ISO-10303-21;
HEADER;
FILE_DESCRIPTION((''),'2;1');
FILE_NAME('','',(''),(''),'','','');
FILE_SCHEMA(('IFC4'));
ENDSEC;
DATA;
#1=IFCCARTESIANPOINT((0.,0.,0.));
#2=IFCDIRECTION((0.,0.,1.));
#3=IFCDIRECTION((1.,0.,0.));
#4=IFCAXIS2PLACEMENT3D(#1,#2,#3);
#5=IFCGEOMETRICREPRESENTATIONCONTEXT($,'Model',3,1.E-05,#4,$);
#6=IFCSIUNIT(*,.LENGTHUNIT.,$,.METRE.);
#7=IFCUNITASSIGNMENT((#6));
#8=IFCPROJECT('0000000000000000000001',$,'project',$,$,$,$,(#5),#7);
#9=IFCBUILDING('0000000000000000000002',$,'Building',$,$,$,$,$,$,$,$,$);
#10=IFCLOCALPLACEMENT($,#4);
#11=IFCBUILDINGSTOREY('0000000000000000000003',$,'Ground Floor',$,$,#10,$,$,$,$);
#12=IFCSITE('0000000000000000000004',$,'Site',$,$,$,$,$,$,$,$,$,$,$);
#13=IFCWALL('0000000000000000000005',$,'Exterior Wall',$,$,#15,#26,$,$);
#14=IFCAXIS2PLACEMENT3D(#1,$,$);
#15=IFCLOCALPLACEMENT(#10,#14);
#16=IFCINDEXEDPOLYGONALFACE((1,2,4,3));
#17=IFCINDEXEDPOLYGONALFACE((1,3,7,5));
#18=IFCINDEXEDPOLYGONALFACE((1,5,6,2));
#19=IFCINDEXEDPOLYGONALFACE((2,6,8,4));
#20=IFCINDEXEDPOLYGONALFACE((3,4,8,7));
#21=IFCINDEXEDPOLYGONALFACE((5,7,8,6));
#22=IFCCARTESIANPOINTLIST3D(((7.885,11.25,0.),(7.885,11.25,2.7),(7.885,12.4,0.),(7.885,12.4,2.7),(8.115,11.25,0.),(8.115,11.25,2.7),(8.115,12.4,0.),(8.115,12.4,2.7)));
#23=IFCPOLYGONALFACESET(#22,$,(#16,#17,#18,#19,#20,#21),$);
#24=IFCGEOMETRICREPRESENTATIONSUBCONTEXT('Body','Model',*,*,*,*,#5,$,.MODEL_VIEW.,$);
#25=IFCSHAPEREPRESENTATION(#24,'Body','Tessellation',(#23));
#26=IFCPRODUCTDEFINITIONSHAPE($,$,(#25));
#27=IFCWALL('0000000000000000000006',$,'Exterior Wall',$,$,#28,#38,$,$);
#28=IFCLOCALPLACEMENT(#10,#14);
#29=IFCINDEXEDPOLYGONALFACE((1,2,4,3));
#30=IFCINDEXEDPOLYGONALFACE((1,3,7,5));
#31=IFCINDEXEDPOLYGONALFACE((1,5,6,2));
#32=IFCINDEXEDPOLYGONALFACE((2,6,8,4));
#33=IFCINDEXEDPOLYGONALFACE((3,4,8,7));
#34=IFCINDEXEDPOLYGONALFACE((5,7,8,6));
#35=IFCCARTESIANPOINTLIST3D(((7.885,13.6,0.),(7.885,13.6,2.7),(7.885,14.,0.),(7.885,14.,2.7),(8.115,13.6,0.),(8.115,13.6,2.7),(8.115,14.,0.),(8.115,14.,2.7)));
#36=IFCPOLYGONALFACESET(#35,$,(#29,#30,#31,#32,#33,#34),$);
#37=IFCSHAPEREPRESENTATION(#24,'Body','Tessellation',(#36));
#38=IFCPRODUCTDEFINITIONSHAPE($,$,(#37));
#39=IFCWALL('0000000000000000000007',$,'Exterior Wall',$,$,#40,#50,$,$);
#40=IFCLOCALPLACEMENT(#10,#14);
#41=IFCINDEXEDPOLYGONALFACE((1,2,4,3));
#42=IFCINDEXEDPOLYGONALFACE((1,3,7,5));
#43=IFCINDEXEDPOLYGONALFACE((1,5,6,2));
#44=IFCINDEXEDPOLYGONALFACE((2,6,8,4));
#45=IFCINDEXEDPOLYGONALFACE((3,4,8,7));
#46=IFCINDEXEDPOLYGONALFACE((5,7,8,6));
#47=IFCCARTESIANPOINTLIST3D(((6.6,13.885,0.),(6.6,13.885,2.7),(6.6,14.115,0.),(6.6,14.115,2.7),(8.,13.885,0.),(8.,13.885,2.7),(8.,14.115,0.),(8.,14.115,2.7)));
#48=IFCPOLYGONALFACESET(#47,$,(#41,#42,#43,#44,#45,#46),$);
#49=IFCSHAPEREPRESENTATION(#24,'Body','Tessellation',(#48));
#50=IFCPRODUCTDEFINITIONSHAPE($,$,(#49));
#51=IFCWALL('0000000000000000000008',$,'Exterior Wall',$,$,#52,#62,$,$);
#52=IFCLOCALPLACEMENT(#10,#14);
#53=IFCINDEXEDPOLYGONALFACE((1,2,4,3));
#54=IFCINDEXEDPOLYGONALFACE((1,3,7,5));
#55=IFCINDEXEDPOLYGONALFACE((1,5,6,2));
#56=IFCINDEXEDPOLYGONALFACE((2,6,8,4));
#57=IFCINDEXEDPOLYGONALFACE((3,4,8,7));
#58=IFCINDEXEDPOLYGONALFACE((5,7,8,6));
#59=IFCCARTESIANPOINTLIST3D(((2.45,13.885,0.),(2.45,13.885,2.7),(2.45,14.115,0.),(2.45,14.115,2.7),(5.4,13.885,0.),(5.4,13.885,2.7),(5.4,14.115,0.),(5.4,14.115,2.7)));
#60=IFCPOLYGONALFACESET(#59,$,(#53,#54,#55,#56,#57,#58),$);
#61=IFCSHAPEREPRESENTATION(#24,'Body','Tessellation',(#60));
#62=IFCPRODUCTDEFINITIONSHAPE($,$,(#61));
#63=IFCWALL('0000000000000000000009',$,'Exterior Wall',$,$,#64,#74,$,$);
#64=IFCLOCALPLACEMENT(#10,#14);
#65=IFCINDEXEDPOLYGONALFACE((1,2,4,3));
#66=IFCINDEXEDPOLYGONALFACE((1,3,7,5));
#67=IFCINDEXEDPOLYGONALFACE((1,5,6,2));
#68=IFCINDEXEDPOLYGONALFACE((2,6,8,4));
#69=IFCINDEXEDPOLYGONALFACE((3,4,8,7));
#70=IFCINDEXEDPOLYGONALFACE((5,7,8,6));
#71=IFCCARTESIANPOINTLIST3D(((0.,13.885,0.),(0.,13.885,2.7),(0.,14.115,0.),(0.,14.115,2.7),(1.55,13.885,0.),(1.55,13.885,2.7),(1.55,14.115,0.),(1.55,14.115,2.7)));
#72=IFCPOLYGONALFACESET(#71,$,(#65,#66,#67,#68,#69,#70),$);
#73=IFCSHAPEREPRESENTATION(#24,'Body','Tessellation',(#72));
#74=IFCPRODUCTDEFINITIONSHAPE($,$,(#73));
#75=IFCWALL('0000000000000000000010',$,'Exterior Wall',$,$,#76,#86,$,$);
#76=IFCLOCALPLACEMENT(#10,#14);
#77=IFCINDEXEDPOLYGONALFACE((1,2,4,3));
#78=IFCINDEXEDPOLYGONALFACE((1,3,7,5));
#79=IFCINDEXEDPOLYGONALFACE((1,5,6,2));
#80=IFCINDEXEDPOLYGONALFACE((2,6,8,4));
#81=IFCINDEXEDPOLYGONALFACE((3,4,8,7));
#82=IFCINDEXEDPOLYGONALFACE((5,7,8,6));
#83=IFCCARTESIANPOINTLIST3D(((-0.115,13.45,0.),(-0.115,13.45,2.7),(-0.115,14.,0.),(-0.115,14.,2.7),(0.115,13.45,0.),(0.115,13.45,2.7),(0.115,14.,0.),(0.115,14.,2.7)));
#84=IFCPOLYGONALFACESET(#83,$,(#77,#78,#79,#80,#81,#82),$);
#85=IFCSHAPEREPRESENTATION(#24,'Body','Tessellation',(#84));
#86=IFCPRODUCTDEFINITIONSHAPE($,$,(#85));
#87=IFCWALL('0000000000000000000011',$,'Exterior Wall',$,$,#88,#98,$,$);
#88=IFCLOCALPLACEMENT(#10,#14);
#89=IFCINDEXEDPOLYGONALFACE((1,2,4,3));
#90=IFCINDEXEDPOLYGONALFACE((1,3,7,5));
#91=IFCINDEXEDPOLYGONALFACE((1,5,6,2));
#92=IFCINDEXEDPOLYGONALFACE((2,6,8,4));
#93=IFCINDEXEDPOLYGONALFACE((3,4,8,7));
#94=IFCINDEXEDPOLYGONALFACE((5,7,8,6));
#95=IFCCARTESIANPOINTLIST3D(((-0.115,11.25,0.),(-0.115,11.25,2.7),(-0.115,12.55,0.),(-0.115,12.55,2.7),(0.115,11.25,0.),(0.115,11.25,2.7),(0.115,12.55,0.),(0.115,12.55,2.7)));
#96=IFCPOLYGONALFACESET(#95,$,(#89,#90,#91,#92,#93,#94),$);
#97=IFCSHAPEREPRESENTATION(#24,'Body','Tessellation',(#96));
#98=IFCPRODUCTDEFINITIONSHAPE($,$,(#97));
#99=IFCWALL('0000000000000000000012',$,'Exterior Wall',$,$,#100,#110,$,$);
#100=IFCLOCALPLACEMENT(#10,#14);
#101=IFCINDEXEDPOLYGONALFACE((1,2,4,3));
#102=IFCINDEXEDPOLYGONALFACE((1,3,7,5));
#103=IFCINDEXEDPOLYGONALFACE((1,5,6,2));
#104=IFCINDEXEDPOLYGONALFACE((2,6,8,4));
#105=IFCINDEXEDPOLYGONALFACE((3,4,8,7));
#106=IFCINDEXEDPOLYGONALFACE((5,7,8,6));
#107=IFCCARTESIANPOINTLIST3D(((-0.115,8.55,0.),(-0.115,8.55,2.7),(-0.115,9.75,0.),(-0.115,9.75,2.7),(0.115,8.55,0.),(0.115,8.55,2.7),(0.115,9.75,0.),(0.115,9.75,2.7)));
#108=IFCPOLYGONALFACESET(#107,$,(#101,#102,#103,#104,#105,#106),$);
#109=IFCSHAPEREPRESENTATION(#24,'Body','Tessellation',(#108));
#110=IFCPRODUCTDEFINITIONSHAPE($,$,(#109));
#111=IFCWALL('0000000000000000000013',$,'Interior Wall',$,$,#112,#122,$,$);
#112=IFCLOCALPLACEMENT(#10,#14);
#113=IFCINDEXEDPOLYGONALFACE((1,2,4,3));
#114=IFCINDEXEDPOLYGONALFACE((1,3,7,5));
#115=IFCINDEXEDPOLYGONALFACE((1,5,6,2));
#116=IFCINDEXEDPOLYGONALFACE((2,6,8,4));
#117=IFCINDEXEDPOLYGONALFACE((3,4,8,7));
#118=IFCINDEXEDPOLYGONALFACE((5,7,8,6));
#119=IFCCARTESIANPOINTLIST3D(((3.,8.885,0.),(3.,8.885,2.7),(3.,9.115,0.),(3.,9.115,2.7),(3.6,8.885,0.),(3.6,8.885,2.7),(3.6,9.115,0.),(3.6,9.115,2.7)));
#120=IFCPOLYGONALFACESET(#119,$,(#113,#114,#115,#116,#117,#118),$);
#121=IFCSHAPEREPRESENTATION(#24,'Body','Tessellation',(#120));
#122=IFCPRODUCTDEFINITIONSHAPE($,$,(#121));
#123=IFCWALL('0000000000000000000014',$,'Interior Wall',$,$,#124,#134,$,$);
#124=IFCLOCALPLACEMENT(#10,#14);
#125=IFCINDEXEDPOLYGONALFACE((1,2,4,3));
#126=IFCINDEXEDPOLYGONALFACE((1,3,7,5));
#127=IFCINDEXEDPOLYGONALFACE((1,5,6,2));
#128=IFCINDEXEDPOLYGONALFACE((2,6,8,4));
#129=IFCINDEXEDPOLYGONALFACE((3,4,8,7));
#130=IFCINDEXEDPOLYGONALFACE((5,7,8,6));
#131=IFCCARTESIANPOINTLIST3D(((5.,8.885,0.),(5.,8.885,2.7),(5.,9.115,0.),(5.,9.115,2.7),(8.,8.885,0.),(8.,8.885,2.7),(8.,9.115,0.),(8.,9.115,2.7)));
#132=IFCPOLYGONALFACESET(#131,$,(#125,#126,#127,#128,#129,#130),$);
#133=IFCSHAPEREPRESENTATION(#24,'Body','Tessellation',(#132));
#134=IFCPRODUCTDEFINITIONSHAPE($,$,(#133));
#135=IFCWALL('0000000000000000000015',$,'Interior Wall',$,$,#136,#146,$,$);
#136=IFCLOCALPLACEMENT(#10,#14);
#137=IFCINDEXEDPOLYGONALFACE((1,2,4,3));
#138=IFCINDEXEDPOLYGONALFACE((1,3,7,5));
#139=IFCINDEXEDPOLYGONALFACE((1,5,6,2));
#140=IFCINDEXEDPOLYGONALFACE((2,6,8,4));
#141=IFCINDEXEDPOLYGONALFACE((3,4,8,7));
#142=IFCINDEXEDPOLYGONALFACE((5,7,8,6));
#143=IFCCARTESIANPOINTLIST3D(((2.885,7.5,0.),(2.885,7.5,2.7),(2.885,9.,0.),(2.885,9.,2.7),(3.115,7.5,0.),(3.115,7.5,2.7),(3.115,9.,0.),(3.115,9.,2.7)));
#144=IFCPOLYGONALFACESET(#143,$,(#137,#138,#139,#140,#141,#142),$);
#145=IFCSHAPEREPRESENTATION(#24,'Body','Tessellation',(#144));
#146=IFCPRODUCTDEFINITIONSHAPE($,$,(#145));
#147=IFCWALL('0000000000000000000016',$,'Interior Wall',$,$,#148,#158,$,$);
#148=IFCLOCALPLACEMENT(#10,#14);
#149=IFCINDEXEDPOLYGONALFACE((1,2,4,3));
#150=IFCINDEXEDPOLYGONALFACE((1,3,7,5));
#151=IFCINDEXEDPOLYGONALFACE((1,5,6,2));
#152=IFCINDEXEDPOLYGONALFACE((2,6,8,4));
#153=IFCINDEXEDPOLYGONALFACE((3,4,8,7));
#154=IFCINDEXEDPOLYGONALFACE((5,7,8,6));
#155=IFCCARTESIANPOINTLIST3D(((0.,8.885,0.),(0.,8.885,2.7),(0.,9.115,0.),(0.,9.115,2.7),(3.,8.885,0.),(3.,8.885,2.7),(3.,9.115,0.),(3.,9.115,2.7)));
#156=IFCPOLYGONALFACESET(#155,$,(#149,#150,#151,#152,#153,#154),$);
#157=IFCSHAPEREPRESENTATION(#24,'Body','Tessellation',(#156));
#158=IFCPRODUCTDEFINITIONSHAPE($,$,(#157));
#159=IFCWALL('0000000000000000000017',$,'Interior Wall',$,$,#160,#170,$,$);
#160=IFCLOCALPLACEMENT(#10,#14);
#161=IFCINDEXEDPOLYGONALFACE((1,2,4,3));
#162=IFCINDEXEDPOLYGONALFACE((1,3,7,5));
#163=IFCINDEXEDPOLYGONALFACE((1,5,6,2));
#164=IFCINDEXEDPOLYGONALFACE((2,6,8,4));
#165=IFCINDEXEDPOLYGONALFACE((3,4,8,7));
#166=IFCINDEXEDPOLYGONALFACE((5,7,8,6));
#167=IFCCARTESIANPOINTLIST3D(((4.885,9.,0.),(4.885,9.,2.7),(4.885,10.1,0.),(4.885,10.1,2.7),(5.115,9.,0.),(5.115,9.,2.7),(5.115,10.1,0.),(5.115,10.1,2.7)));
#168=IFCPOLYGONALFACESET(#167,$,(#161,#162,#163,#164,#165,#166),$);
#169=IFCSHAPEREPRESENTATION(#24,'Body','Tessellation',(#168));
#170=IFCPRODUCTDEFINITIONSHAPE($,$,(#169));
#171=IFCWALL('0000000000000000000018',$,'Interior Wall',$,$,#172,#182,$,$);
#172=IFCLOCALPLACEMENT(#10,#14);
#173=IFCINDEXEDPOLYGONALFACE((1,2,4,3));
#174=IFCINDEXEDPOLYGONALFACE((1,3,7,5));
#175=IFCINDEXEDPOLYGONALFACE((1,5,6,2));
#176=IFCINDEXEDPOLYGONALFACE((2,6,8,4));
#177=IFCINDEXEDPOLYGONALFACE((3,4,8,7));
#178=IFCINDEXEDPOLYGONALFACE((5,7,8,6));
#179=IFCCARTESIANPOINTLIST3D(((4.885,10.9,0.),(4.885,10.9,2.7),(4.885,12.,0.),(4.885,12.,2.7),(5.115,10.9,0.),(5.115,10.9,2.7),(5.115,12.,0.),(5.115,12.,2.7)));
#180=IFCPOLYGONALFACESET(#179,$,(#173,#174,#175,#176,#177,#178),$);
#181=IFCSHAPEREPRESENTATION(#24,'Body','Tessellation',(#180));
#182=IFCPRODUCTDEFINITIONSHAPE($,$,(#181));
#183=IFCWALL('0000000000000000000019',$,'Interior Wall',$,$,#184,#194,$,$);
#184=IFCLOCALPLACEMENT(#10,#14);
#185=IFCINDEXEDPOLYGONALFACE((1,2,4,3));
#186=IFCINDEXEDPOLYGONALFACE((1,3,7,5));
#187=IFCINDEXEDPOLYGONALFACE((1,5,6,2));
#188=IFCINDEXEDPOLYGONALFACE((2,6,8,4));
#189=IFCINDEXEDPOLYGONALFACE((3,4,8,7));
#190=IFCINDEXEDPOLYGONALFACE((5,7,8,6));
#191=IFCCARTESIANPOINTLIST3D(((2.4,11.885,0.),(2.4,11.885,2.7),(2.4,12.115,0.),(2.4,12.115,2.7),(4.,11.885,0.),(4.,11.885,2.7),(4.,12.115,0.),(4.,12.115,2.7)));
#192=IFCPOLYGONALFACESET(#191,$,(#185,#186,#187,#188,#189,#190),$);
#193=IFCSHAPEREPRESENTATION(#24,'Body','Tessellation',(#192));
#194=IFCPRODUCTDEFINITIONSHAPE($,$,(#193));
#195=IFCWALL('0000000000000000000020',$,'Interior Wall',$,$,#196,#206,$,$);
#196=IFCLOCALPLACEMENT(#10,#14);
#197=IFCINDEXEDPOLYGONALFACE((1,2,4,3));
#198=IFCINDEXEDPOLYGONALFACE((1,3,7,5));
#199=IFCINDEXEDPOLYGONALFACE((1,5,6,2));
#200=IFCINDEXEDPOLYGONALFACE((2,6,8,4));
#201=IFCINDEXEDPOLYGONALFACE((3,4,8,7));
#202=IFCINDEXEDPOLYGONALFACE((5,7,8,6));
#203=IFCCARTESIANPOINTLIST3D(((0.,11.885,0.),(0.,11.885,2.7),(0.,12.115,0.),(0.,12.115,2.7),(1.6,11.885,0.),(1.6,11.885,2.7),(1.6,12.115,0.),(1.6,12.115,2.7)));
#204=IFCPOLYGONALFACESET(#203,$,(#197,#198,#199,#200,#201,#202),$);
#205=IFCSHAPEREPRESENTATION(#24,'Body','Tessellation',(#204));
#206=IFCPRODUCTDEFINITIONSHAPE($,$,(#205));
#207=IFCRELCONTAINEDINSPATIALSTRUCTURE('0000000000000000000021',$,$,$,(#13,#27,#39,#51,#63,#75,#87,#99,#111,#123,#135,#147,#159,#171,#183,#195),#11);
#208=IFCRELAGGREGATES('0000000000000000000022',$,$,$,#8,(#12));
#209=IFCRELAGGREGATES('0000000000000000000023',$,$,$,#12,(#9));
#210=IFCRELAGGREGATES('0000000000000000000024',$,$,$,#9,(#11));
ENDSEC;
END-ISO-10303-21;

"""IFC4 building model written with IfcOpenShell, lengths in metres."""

from ifc_helpers import new_model, si_unit, frame, origin_with_axes, place, context, subcontext, project, spatial, indexed_curve, outline, extrude, element, save


model = new_model("IFC4")

# Units and contexts
model_context = context("Model", 3, precision=1e-05, world=origin_with_axes())
body_context = subcontext(model_context, "Body", "Model", "MODEL_VIEW")
ifc_project = project(units=[si_unit("LENGTHUNIT", "METRE")], contexts=[model_context])

# Site, building, storey
site = spatial("IfcSite", under=ifc_project, Name="Site")
building = spatial("IfcBuilding", under=site, Name="Building")
storey_placement = place(None, origin_with_axes())
storey = spatial("IfcBuildingStorey", under=building, at=storey_placement, Name="Ground Floor")

# Walls
wall_1_placement = place(storey_placement, frame((8.0, 11.25, 0.0), z_axis=(0.0, 0.0, 1.0), x_axis=(0.0, 1.0, 0.0)))
element("IfcWall", 1, at=wall_1_placement, inside=storey, Name="Exterior Wall", context=body_context, shape_type="SweptSolid", body=[
    extrude(outline(indexed_curve([(0.0, 0.0), (0.0, 0.23), (1.15, 0.23), (1.15, 0.0), (0.0, 0.0)], self_intersect=False)), frame((0.0, -0.115, 0.0), z_axis=(0.0, 0.0, 1.0), x_axis=(1.0, 0.0, 0.0)), (0.0, 0.0, 1.0), 2.7),
])
wall_2_placement = place(storey_placement, frame((8.0, 13.6, 0.0), z_axis=(0.0, 0.0, 1.0), x_axis=(0.0, 1.0, 0.0)))
element("IfcWall", 2, at=wall_2_placement, inside=storey, Name="Exterior Wall", context=body_context, shape_type="SweptSolid", body=[
    extrude(outline(indexed_curve([(0.0, 0.0), (0.0, 0.23), (0.4, 0.23), (0.4, 0.0), (0.0, 0.0)], self_intersect=False)), frame((0.0, -0.115, 0.0), z_axis=(0.0, 0.0, 1.0), x_axis=(1.0, 0.0, 0.0)), (0.0, 0.0, 1.0), 2.7),
])
wall_3_placement = place(storey_placement, frame((8.0, 14.0, 0.0), z_axis=(0.0, 0.0, 1.0), x_axis=(-1.0, 0.0, 0.0)))
element("IfcWall", 3, at=wall_3_placement, inside=storey, Name="Exterior Wall", context=body_context, shape_type="SweptSolid", body=[
    extrude(outline(indexed_curve([(0.0, 0.0), (0.0, 0.23), (1.4, 0.23), (1.4, 0.0), (0.0, 0.0)], self_intersect=False)), frame((0.0, -0.115, 0.0), z_axis=(0.0, 0.0, 1.0), x_axis=(1.0, 0.0, 0.0)), (0.0, 0.0, 1.0), 2.7),
])
wall_4_placement = place(storey_placement, frame((5.4, 14.0, 0.0), z_axis=(0.0, 0.0, 1.0), x_axis=(-1.0, 0.0, 0.0)))
element("IfcWall", 4, at=wall_4_placement, inside=storey, Name="Exterior Wall", context=body_context, shape_type="SweptSolid", body=[
    extrude(outline(indexed_curve([(0.0, 0.0), (0.0, 0.23), (2.95, 0.23), (2.95, 0.0), (0.0, 0.0)], self_intersect=False)), frame((0.0, -0.115, 0.0), z_axis=(0.0, 0.0, 1.0), x_axis=(1.0, 0.0, 0.0)), (0.0, 0.0, 1.0), 2.7),
])
wall_5_placement = place(storey_placement, frame((1.55, 14.0, 0.0), z_axis=(0.0, 0.0, 1.0), x_axis=(-1.0, 0.0, 0.0)))
element("IfcWall", 5, at=wall_5_placement, inside=storey, Name="Exterior Wall", context=body_context, shape_type="SweptSolid", body=[
    extrude(outline(indexed_curve([(0.0, 0.0), (0.0, 0.23), (1.55, 0.23), (1.55, 0.0), (0.0, 0.0)], self_intersect=False)), frame((0.0, -0.115, 0.0), z_axis=(0.0, 0.0, 1.0), x_axis=(1.0, 0.0, 0.0)), (0.0, 0.0, 1.0), 2.7),
])
wall_6_placement = place(storey_placement, frame((0.0, 14.0, 0.0), z_axis=(0.0, 0.0, 1.0), x_axis=(0.0, -1.0, 0.0)))
element("IfcWall", 6, at=wall_6_placement, inside=storey, Name="Exterior Wall", context=body_context, shape_type="SweptSolid", body=[
    extrude(outline(indexed_curve([(0.0, 0.0), (0.0, 0.23), (0.55, 0.23), (0.55, 0.0), (0.0, 0.0)], self_intersect=False)), frame((0.0, -0.115, 0.0), z_axis=(0.0, 0.0, 1.0), x_axis=(1.0, 0.0, 0.0)), (0.0, 0.0, 1.0), 2.7),
])
wall_7_placement = place(storey_placement, frame((0.0, 12.55, 0.0), z_axis=(0.0, 0.0, 1.0), x_axis=(0.0, -1.0, 0.0)))
element("IfcWall", 7, at=wall_7_placement, inside=storey, Name="Exterior Wall", context=body_context, shape_type="SweptSolid", body=[
    extrude(outline(indexed_curve([(0.0, 0.0), (0.0, 0.23), (1.3, 0.23), (1.3, 0.0), (0.0, 0.0)], self_intersect=False)), frame((0.0, -0.115, 0.0), z_axis=(0.0, 0.0, 1.0), x_axis=(1.0, 0.0, 0.0)), (0.0, 0.0, 1.0), 2.7),
])
wall_8_placement = place(storey_placement, frame((0.0, 9.75, 0.0), z_axis=(0.0, 0.0, 1.0), x_axis=(0.0, -1.0, 0.0)))
element("IfcWall", 8, at=wall_8_placement, inside=storey, Name="Exterior Wall", context=body_context, shape_type="SweptSolid", body=[
    extrude(outline(indexed_curve([(0.0, 0.0), (0.0, 0.23), (1.2, 0.23), (1.2, 0.0), (0.0, 0.0)], self_intersect=False)), frame((0.0, -0.115, 0.0), z_axis=(0.0, 0.0, 1.0), x_axis=(1.0, 0.0, 0.0)), (0.0, 0.0, 1.0), 2.7),
])
wall_9_placement = place(storey_placement, frame((3.6, 9.0, 0.0), z_axis=(0.0, 0.0, 1.0), x_axis=(-1.0, 0.0, 0.0)))
element("IfcWall", 9, at=wall_9_placement, inside=storey, Name="Interior Wall", context=body_context, shape_type="SweptSolid", body=[
    extrude(outline(indexed_curve([(0.0, 0.0), (0.0, 0.23), (0.6, 0.23), (0.6, 0.0), (0.0, 0.0)], self_intersect=False)), frame((0.0, -0.115, 0.0), z_axis=(0.0, 0.0, 1.0), x_axis=(1.0, 0.0, 0.0)), (0.0, 0.0, 1.0), 2.7),
])
wall_10_placement = place(storey_placement, frame((8.0, 9.0, 0.0), z_axis=(0.0, 0.0, 1.0), x_axis=(-1.0, 0.0, 0.0)))
element("IfcWall", 10, at=wall_10_placement, inside=storey, Name="Interior Wall", context=body_context, shape_type="SweptSolid", body=[
    extrude(outline(indexed_curve([(0.0, 0.0), (0.0, 0.23), (3.0, 0.23), (3.0, 0.0), (0.0, 0.0)], self_intersect=False)), frame((0.0, -0.115, 0.0), z_axis=(0.0, 0.0, 1.0), x_axis=(1.0, 0.0, 0.0)), (0.0, 0.0, 1.0), 2.7),
])
wall_11_placement = place(storey_placement, frame((3.0, 9.0, 0.0), z_axis=(0.0, 0.0, 1.0), x_axis=(0.0, -1.0, 0.0)))
element("IfcWall", 11, at=wall_11_placement, inside=storey, Name="Interior Wall", context=body_context, shape_type="SweptSolid", body=[
    extrude(outline(indexed_curve([(0.0, 0.0), (0.0, 0.23), (1.5, 0.23), (1.5, 0.0), (0.0, 0.0)], self_intersect=False)), frame((0.0, -0.115, 0.0), z_axis=(0.0, 0.0, 1.0), x_axis=(1.0, 0.0, 0.0)), (0.0, 0.0, 1.0), 2.7),
])
wall_12_placement = place(storey_placement, frame((3.0, 9.0, 0.0), z_axis=(0.0, 0.0, 1.0), x_axis=(-1.0, 0.0, 0.0)))
element("IfcWall", 12, at=wall_12_placement, inside=storey, Name="Interior Wall", context=body_context, shape_type="SweptSolid", body=[
    extrude(outline(indexed_curve([(0.0, 0.0), (0.0, 0.23), (3.0, 0.23), (3.0, 0.0), (0.0, 0.0)], self_intersect=False)), frame((0.0, -0.115, 0.0), z_axis=(0.0, 0.0, 1.0), x_axis=(1.0, 0.0, 0.0)), (0.0, 0.0, 1.0), 2.7),
])
for number, where, z_axis, x_axis, name in (
    (13, (5.0, 9.0, 0.0), (0.0, 0.0, 1.0), (0.0, 1.0, 0.0), "Interior Wall"),
    (14, (5.0, 10.9, 0.0), (0.0, 0.0, 1.0), (0.0, 1.0, 0.0), "Interior Wall"),
):
    element("IfcWall", number, at=place(storey_placement, frame(where, z_axis=z_axis, x_axis=x_axis)), inside=storey, Name=name, context=body_context, shape_type="SweptSolid", body=[
        extrude(outline(indexed_curve([(0.0, 0.0), (0.0, 0.23), (1.1, 0.23), (1.1, 0.0), (0.0, 0.0)], self_intersect=False)), frame((0.0, -0.115, 0.0), z_axis=(0.0, 0.0, 1.0), x_axis=(1.0, 0.0, 0.0)), (0.0, 0.0, 1.0), 2.7),
    ])
for number, where, z_axis, x_axis, name in (
    (15, (4.0, 12.0, 0.0), (0.0, 0.0, 1.0), (-1.0, 0.0, 0.0), "Interior Wall"),
    (16, (1.6, 12.0, 0.0), (0.0, 0.0, 1.0), (-1.0, 0.0, 0.0), "Interior Wall"),
):
    element("IfcWall", number, at=place(storey_placement, frame(where, z_axis=z_axis, x_axis=x_axis)), inside=storey, Name=name, context=body_context, shape_type="SweptSolid", body=[
        extrude(outline(indexed_curve([(0.0, 0.0), (0.0, 0.23), (1.6, 0.23), (1.6, 0.0), (0.0, 0.0)], self_intersect=False)), frame((0.0, -0.115, 0.0), z_axis=(0.0, 0.0, 1.0), x_axis=(1.0, 0.0, 0.0)), (0.0, 0.0, 1.0), 2.7),
    ])

save(model, "model.ifc")
